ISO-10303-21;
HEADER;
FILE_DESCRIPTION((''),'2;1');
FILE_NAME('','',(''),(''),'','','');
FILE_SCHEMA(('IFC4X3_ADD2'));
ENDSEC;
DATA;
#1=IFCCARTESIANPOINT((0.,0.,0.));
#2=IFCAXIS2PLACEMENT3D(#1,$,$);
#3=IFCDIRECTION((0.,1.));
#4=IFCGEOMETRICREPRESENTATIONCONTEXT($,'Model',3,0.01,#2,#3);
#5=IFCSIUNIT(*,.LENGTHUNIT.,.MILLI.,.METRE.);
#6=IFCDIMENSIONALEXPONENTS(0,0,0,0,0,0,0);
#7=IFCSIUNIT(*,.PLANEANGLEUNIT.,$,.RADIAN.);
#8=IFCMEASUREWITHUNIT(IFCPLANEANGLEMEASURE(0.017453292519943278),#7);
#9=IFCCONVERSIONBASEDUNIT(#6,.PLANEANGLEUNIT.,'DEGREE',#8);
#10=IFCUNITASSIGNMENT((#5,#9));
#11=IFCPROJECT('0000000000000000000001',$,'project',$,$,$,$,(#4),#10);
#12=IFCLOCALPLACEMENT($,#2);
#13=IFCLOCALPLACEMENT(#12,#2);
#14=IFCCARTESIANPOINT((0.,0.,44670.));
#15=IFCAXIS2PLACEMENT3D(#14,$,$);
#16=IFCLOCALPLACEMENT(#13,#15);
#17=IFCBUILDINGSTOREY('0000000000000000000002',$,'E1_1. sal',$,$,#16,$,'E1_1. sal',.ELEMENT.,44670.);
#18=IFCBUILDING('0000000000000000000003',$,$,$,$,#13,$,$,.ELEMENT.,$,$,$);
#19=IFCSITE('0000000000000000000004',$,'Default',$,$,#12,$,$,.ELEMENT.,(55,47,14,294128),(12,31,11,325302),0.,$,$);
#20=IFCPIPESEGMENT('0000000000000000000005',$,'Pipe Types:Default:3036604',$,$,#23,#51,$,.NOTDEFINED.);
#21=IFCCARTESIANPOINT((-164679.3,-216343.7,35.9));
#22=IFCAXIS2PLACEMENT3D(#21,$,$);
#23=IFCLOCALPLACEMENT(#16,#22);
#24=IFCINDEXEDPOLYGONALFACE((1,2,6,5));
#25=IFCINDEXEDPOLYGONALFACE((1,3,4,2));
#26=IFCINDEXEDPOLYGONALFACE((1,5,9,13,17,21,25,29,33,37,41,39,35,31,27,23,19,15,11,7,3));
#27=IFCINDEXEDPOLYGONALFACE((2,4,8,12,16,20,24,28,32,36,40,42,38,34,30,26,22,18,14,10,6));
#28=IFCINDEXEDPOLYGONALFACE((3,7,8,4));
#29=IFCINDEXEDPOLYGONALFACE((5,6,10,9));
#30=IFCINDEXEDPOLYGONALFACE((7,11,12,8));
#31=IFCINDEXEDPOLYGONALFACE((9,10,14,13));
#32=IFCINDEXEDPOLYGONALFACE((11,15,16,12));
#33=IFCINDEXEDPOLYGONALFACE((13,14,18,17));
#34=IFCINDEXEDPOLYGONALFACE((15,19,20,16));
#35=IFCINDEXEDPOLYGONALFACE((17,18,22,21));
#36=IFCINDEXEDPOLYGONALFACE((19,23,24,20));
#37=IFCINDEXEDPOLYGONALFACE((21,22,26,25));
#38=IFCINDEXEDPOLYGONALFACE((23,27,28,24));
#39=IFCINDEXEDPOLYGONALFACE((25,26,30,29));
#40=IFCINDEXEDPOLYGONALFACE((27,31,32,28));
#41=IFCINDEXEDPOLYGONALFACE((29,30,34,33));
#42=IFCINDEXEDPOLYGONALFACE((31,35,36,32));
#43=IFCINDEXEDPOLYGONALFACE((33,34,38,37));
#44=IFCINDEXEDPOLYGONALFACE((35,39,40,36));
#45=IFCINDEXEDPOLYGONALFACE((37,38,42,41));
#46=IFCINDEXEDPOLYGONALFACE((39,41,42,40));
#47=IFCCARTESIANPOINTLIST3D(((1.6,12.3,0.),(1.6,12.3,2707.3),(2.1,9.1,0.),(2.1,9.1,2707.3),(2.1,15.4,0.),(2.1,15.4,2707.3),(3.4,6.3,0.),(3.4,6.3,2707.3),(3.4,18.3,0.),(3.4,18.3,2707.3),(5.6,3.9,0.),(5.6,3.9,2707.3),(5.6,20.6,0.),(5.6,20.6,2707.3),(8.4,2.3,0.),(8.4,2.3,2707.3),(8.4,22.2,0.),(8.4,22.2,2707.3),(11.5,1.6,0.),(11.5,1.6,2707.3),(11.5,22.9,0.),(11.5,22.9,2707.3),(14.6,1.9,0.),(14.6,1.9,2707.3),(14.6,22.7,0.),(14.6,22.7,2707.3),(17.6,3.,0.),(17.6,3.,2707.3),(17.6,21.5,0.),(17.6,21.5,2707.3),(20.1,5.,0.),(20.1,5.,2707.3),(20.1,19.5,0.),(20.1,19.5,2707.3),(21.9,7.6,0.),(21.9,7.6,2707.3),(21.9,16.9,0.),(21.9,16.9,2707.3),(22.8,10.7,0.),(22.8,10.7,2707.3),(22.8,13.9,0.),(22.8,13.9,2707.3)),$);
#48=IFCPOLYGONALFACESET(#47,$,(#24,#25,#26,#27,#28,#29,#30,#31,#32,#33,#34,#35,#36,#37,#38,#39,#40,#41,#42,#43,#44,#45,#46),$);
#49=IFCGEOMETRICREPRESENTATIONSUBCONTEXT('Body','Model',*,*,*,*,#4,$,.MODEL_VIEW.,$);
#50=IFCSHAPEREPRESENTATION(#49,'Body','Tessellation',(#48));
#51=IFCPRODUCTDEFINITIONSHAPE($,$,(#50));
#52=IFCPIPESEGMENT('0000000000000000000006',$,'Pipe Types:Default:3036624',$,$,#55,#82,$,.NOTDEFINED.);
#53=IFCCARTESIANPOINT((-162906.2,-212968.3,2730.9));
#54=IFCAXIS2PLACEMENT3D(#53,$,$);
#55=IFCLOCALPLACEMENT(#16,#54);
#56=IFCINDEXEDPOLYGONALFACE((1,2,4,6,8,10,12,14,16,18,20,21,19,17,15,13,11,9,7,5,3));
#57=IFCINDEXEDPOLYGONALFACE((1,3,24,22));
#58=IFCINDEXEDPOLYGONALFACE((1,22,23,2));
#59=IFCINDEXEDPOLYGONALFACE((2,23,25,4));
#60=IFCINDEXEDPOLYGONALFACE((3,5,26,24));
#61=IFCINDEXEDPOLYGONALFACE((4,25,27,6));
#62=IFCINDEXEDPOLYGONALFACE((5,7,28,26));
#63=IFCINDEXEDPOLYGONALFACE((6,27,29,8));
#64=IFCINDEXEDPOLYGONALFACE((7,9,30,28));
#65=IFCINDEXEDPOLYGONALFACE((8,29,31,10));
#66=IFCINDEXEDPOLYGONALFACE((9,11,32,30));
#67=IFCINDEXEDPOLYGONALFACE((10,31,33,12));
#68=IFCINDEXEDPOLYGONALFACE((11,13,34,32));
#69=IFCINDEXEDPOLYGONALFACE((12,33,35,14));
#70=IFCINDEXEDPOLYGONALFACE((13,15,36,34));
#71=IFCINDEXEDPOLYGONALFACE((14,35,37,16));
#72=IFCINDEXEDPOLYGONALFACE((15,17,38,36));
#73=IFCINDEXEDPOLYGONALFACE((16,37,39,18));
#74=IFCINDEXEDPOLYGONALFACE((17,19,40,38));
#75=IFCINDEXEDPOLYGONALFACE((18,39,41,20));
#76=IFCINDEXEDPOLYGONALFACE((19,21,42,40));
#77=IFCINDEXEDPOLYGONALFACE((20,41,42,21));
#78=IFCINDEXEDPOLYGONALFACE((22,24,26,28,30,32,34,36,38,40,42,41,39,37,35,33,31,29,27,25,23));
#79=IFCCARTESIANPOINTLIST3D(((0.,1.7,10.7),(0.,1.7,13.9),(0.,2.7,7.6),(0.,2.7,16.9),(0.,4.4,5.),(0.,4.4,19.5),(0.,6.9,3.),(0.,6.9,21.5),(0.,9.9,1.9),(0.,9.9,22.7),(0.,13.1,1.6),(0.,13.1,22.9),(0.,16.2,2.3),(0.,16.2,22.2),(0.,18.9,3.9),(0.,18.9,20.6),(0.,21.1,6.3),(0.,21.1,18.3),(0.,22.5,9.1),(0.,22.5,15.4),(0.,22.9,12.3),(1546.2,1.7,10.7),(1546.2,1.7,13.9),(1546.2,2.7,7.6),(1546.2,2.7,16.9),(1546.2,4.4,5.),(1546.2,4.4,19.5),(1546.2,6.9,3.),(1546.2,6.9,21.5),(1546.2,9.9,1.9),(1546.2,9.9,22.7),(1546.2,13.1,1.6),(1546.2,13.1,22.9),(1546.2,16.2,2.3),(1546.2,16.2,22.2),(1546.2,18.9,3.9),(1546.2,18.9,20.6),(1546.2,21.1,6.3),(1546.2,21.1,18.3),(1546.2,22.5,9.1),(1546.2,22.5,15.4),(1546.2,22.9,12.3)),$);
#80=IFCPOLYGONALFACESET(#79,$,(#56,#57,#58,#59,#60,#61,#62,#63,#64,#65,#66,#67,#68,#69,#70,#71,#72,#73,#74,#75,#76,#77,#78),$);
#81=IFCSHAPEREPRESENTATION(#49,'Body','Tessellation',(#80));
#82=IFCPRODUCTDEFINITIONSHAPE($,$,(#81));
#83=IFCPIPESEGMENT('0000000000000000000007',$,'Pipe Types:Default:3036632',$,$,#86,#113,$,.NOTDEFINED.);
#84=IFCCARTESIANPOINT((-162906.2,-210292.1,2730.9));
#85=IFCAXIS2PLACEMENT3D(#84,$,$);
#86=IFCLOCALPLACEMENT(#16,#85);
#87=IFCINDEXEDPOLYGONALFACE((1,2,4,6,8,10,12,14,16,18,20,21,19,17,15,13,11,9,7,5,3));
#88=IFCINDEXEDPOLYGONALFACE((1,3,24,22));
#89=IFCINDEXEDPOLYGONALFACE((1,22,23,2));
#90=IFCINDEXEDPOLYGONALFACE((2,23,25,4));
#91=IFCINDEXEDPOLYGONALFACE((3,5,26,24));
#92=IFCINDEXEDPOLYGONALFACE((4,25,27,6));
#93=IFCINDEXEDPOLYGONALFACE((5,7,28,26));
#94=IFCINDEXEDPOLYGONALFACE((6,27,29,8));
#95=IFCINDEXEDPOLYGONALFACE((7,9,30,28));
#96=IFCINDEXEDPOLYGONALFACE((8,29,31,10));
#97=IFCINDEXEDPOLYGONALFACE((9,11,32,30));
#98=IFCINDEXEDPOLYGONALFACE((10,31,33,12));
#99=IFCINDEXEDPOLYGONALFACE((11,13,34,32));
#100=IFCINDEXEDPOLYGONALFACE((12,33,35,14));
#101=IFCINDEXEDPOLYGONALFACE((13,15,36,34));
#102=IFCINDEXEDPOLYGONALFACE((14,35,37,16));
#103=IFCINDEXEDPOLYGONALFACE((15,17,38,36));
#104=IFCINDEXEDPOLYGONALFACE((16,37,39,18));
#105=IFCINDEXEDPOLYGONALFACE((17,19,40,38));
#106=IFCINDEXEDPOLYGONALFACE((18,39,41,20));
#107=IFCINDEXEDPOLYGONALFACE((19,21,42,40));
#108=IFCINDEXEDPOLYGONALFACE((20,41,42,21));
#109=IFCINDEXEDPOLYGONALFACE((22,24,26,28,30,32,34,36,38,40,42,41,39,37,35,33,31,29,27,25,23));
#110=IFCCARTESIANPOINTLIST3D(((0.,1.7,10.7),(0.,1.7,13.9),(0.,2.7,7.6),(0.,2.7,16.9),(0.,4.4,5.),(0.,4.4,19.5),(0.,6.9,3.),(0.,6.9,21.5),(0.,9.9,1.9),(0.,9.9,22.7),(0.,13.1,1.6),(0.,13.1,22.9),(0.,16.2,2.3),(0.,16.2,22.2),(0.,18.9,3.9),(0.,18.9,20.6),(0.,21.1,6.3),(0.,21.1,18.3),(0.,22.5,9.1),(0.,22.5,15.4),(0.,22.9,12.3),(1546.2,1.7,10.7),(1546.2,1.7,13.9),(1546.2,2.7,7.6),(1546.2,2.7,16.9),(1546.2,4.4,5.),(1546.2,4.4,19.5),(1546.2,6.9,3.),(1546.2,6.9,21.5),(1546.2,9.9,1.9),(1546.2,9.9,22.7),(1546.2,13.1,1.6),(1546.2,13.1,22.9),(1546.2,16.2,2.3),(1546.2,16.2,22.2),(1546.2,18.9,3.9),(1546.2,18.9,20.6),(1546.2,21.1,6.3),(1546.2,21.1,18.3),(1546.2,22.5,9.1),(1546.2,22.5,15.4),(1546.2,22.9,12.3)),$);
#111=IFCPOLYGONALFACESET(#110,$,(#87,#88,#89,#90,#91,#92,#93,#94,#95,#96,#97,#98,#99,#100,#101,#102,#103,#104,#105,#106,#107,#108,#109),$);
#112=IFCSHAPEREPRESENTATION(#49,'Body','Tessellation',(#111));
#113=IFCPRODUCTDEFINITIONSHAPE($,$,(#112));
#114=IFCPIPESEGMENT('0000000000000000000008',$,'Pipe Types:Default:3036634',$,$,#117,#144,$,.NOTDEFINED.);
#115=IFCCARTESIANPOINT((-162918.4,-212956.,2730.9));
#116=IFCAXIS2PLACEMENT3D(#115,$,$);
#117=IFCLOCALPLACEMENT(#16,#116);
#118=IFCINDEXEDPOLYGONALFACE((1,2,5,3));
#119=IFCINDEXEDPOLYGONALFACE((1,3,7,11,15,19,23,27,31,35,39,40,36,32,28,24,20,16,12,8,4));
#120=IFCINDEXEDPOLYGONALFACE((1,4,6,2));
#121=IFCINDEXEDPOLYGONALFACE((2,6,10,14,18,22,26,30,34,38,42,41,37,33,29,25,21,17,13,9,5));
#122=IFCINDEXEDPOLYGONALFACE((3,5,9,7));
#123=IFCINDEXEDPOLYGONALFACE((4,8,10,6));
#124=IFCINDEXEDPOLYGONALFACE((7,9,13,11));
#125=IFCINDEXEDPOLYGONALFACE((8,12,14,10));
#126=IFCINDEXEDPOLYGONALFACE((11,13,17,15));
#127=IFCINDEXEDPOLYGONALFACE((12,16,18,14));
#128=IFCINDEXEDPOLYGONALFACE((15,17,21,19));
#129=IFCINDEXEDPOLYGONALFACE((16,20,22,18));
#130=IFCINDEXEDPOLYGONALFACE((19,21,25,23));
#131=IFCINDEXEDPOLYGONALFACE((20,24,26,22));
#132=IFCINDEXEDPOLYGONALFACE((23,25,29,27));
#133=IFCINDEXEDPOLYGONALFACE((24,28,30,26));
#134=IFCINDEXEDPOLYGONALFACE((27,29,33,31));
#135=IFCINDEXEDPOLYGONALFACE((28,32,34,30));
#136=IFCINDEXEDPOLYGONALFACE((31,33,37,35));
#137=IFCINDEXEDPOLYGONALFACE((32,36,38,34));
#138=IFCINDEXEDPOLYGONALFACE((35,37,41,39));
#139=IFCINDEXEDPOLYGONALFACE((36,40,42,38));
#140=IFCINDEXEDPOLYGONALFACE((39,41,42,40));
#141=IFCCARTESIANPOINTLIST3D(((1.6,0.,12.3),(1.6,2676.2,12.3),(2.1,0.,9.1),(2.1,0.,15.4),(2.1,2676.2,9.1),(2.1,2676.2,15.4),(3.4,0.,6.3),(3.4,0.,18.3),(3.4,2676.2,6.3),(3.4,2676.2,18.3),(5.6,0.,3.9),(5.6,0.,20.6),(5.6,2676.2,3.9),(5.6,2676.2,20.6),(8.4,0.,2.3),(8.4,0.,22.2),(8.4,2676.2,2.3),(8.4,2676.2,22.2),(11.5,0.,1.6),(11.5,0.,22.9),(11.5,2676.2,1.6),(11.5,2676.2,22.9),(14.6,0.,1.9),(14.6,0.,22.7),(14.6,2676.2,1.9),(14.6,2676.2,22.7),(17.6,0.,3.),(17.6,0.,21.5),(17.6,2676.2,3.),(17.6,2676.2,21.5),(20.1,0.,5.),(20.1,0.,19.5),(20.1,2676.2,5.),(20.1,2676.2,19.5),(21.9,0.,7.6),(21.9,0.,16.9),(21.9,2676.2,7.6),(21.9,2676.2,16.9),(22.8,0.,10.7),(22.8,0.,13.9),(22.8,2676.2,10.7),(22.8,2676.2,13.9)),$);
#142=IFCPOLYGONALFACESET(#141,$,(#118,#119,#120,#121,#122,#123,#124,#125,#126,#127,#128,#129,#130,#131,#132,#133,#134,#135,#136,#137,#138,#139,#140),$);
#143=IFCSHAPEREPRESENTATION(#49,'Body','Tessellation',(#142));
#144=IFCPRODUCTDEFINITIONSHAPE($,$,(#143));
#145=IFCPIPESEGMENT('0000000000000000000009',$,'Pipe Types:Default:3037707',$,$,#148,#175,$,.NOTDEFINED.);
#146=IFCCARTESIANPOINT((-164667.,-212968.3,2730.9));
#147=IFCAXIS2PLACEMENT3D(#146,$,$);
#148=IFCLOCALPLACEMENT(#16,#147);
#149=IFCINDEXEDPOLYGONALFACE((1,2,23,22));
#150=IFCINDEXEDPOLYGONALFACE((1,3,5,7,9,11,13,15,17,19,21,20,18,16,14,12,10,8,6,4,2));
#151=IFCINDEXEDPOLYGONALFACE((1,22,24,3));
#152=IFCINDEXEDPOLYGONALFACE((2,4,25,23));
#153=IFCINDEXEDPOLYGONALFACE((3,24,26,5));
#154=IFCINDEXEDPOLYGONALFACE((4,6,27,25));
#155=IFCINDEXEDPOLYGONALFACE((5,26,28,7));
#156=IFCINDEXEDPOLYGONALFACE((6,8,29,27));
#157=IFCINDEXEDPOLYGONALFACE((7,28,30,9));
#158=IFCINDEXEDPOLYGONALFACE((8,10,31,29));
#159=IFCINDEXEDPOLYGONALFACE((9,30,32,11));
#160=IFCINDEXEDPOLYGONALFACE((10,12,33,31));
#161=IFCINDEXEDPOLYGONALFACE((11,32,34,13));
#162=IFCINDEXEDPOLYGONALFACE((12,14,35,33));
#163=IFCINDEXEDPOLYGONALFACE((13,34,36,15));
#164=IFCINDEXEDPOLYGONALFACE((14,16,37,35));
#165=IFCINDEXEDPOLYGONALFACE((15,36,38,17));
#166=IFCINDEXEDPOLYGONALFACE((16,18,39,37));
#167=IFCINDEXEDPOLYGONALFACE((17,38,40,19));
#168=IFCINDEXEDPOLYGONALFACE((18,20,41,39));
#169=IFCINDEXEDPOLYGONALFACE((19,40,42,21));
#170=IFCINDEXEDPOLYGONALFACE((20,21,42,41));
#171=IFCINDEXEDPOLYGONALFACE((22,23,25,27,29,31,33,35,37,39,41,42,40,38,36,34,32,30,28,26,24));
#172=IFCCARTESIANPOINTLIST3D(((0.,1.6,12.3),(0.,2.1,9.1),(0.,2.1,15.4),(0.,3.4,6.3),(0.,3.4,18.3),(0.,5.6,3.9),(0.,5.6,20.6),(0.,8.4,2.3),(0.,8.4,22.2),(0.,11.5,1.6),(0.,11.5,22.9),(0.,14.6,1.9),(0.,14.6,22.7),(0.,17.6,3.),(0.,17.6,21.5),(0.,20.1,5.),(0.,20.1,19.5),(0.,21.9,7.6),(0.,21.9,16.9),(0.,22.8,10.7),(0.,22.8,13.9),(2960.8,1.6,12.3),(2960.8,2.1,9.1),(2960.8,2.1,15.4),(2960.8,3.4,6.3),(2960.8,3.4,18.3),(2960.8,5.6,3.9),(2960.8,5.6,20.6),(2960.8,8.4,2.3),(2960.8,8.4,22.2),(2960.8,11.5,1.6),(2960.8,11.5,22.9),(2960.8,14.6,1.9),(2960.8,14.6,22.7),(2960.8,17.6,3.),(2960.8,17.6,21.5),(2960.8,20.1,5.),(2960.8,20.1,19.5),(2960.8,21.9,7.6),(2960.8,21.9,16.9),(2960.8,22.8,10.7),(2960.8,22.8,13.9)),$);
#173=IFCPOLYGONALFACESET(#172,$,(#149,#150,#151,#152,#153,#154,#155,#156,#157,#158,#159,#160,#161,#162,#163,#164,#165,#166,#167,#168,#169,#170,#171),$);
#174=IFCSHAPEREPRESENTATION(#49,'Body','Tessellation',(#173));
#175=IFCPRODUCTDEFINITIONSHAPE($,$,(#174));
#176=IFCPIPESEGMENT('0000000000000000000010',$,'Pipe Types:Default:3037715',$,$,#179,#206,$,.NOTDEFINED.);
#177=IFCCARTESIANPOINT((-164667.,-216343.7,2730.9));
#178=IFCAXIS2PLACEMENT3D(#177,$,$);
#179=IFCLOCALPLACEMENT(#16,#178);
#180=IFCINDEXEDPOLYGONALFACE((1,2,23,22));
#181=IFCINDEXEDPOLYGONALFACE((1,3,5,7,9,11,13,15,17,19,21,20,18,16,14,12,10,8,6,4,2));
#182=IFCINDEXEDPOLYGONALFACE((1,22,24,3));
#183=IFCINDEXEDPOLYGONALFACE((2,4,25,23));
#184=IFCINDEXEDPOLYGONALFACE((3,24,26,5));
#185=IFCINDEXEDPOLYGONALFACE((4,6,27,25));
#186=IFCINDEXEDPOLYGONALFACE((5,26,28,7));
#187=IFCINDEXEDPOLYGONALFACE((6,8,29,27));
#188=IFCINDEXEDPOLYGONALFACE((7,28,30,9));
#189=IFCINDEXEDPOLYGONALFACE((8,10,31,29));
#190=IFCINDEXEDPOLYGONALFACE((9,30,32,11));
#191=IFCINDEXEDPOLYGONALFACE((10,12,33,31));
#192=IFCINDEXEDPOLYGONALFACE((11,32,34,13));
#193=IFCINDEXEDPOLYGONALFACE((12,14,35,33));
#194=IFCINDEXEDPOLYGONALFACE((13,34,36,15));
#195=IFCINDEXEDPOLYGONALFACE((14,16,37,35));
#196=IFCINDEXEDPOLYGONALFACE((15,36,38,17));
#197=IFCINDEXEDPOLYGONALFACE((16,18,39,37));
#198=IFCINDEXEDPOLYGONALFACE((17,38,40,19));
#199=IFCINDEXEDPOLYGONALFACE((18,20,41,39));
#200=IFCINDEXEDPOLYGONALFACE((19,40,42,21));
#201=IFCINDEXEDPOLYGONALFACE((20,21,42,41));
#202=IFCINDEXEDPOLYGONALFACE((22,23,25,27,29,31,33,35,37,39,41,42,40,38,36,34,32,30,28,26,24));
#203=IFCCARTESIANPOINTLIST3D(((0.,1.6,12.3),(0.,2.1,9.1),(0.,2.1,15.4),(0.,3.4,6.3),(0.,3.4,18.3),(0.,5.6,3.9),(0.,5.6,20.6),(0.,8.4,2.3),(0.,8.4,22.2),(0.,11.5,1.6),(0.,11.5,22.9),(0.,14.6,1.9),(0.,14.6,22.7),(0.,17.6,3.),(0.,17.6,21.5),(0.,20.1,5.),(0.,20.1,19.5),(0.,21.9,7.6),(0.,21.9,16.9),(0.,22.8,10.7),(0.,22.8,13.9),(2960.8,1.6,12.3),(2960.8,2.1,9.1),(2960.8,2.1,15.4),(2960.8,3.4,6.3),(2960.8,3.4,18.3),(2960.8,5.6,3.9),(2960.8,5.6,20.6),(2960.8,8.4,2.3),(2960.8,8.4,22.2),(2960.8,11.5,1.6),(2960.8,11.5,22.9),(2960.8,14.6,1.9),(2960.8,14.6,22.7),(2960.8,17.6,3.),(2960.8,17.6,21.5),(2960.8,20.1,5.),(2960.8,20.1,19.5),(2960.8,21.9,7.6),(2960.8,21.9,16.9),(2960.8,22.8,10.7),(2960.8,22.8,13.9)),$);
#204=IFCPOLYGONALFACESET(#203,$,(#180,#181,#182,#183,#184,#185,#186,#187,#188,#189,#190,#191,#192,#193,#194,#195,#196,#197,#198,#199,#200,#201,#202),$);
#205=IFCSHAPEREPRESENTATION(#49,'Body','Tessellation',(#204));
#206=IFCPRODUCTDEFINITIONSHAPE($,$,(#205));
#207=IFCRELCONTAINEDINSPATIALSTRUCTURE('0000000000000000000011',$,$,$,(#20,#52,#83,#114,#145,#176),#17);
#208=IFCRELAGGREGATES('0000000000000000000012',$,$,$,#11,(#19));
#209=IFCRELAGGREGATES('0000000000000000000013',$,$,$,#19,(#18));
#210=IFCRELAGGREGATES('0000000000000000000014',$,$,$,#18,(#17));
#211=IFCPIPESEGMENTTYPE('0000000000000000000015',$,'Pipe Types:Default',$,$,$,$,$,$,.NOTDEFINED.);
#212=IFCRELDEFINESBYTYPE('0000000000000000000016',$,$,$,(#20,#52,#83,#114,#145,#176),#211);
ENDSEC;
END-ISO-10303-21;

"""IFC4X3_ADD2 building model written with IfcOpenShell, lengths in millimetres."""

from ifc_helpers import new_model, entity, si_unit, converted_unit, direction, frame, origin, origin_2d_with_axis, place, context, subcontext, project, spatial, circle, extrude, type_object, element, save


model = new_model("IFC4X3_ADD2")

# Units and contexts
model_context = context("Model", 3, precision=0.01, world=origin(), true_north=direction((0.0, 1.0)))
body_context = subcontext(model_context, "Body", "Model", "MODEL_VIEW")
ifc_project = project(units=[si_unit("LENGTHUNIT", "METRE", prefix="MILLI"), converted_unit("PLANEANGLEUNIT", "DEGREE", entity("IfcPlaneAngleMeasure", 0.017453292519943278), si_unit("PLANEANGLEUNIT", "RADIAN"), dimensions=[0, 0, 0, 0, 0, 0, 0])], contexts=[model_context])

# Site, building, storey
site_placement = place(None, origin())
site = spatial("IfcSite", under=ifc_project, at=site_placement, Name="Default", CompositionType="ELEMENT", RefLatitude=(55, 47, 14, 294128), RefLongitude=(12, 31, 11, 325302), RefElevation=0.0)
building_placement = place(site_placement, origin())
building = spatial("IfcBuilding", under=site, at=building_placement, CompositionType="ELEMENT")
storey_placement = place(building_placement, frame((0.0, 0.0, 44670.0)))
storey = spatial("IfcBuildingStorey", under=building, at=storey_placement, Name="E1_1. sal", LongName="E1_1. sal", CompositionType="ELEMENT", Elevation=44670.0)

# Pipe segments
pipe_segment_type = type_object("IfcPipeSegmentType", Name="Pipe Types:Default", PredefinedType="NOTDEFINED")
pipe_segment_1_placement = place(storey_placement, frame((-164679.3, -216343.7, 35.9)))
element("IfcPipeSegment", 1, at=pipe_segment_1_placement, inside=storey, type_object=pipe_segment_type, Name="Pipe Types:Default:3036604", PredefinedType="NOTDEFINED", context=body_context, shape_type="SweptSolid", body=[
    extrude(circle(Radius=10.7, at=origin_2d_with_axis()), frame((12.3, 12.3, 0.0), z_axis=(0.0, 0.0, 1.0), x_axis=(-1.0, 0.0, 0.0)), (0.0, 0.0, 1.0), 2707.3),
])
for number, where, name in (
    (2, (-162906.2, -212968.3, 2730.9), "Pipe Types:Default:3036624"),
    (3, (-162906.2, -210292.1, 2730.9), "Pipe Types:Default:3036632"),
):
    element("IfcPipeSegment", number, at=place(storey_placement, frame(where)), inside=storey, type_object=pipe_segment_type, Name=name, PredefinedType="NOTDEFINED", context=body_context, shape_type="SweptSolid", body=[
        extrude(circle(Radius=10.7, at=origin_2d_with_axis()), frame((0.0, 12.3, 12.3), z_axis=(1.0, 0.0, 0.0), x_axis=(0.0, 1.0, 0.0)), (0.0, 0.0, 1.0), 1546.2),
    ])
pipe_segment_2_placement = place(storey_placement, frame((-162918.4, -212956.0, 2730.9)))
element("IfcPipeSegment", 4, at=pipe_segment_2_placement, inside=storey, type_object=pipe_segment_type, Name="Pipe Types:Default:3036634", PredefinedType="NOTDEFINED", context=body_context, shape_type="SweptSolid", body=[
    extrude(circle(Radius=10.7, at=origin_2d_with_axis()), frame((12.3, 0.0, 12.3), z_axis=(0.0, 1.0, 0.0), x_axis=(-1.0, 0.0, 0.0)), (0.0, 0.0, 1.0), 2676.2),
])
pipe_segment_3_placement = place(storey_placement, frame((-164667.0, -212968.3, 2730.9)))
element("IfcPipeSegment", 5, at=pipe_segment_3_placement, inside=storey, type_object=pipe_segment_type, Name="Pipe Types:Default:3037707", PredefinedType="NOTDEFINED", context=body_context, shape_type="SweptSolid", body=[
    extrude(circle(Radius=10.7, at=origin_2d_with_axis()), frame((0.0, 12.3, 12.3), z_axis=(1.0, 0.0, 0.0), x_axis=(0.0, -1.0, 0.0)), (0.0, 0.0, 1.0), 2960.8),
])
pipe_segment_4_placement = place(storey_placement, frame((-164667.0, -216343.7, 2730.9)))
element("IfcPipeSegment", 6, at=pipe_segment_4_placement, inside=storey, type_object=pipe_segment_type, Name="Pipe Types:Default:3037715", PredefinedType="NOTDEFINED", context=body_context, shape_type="SweptSolid", body=[
    extrude(circle(Radius=10.7, at=origin_2d_with_axis()), frame((0.0, 12.3, 12.3), z_axis=(1.0, 0.0, 0.0), x_axis=(0.0, -1.0, 0.0)), (0.0, 0.0, 1.0), 2960.8),
])

save(model, "model.ifc")
